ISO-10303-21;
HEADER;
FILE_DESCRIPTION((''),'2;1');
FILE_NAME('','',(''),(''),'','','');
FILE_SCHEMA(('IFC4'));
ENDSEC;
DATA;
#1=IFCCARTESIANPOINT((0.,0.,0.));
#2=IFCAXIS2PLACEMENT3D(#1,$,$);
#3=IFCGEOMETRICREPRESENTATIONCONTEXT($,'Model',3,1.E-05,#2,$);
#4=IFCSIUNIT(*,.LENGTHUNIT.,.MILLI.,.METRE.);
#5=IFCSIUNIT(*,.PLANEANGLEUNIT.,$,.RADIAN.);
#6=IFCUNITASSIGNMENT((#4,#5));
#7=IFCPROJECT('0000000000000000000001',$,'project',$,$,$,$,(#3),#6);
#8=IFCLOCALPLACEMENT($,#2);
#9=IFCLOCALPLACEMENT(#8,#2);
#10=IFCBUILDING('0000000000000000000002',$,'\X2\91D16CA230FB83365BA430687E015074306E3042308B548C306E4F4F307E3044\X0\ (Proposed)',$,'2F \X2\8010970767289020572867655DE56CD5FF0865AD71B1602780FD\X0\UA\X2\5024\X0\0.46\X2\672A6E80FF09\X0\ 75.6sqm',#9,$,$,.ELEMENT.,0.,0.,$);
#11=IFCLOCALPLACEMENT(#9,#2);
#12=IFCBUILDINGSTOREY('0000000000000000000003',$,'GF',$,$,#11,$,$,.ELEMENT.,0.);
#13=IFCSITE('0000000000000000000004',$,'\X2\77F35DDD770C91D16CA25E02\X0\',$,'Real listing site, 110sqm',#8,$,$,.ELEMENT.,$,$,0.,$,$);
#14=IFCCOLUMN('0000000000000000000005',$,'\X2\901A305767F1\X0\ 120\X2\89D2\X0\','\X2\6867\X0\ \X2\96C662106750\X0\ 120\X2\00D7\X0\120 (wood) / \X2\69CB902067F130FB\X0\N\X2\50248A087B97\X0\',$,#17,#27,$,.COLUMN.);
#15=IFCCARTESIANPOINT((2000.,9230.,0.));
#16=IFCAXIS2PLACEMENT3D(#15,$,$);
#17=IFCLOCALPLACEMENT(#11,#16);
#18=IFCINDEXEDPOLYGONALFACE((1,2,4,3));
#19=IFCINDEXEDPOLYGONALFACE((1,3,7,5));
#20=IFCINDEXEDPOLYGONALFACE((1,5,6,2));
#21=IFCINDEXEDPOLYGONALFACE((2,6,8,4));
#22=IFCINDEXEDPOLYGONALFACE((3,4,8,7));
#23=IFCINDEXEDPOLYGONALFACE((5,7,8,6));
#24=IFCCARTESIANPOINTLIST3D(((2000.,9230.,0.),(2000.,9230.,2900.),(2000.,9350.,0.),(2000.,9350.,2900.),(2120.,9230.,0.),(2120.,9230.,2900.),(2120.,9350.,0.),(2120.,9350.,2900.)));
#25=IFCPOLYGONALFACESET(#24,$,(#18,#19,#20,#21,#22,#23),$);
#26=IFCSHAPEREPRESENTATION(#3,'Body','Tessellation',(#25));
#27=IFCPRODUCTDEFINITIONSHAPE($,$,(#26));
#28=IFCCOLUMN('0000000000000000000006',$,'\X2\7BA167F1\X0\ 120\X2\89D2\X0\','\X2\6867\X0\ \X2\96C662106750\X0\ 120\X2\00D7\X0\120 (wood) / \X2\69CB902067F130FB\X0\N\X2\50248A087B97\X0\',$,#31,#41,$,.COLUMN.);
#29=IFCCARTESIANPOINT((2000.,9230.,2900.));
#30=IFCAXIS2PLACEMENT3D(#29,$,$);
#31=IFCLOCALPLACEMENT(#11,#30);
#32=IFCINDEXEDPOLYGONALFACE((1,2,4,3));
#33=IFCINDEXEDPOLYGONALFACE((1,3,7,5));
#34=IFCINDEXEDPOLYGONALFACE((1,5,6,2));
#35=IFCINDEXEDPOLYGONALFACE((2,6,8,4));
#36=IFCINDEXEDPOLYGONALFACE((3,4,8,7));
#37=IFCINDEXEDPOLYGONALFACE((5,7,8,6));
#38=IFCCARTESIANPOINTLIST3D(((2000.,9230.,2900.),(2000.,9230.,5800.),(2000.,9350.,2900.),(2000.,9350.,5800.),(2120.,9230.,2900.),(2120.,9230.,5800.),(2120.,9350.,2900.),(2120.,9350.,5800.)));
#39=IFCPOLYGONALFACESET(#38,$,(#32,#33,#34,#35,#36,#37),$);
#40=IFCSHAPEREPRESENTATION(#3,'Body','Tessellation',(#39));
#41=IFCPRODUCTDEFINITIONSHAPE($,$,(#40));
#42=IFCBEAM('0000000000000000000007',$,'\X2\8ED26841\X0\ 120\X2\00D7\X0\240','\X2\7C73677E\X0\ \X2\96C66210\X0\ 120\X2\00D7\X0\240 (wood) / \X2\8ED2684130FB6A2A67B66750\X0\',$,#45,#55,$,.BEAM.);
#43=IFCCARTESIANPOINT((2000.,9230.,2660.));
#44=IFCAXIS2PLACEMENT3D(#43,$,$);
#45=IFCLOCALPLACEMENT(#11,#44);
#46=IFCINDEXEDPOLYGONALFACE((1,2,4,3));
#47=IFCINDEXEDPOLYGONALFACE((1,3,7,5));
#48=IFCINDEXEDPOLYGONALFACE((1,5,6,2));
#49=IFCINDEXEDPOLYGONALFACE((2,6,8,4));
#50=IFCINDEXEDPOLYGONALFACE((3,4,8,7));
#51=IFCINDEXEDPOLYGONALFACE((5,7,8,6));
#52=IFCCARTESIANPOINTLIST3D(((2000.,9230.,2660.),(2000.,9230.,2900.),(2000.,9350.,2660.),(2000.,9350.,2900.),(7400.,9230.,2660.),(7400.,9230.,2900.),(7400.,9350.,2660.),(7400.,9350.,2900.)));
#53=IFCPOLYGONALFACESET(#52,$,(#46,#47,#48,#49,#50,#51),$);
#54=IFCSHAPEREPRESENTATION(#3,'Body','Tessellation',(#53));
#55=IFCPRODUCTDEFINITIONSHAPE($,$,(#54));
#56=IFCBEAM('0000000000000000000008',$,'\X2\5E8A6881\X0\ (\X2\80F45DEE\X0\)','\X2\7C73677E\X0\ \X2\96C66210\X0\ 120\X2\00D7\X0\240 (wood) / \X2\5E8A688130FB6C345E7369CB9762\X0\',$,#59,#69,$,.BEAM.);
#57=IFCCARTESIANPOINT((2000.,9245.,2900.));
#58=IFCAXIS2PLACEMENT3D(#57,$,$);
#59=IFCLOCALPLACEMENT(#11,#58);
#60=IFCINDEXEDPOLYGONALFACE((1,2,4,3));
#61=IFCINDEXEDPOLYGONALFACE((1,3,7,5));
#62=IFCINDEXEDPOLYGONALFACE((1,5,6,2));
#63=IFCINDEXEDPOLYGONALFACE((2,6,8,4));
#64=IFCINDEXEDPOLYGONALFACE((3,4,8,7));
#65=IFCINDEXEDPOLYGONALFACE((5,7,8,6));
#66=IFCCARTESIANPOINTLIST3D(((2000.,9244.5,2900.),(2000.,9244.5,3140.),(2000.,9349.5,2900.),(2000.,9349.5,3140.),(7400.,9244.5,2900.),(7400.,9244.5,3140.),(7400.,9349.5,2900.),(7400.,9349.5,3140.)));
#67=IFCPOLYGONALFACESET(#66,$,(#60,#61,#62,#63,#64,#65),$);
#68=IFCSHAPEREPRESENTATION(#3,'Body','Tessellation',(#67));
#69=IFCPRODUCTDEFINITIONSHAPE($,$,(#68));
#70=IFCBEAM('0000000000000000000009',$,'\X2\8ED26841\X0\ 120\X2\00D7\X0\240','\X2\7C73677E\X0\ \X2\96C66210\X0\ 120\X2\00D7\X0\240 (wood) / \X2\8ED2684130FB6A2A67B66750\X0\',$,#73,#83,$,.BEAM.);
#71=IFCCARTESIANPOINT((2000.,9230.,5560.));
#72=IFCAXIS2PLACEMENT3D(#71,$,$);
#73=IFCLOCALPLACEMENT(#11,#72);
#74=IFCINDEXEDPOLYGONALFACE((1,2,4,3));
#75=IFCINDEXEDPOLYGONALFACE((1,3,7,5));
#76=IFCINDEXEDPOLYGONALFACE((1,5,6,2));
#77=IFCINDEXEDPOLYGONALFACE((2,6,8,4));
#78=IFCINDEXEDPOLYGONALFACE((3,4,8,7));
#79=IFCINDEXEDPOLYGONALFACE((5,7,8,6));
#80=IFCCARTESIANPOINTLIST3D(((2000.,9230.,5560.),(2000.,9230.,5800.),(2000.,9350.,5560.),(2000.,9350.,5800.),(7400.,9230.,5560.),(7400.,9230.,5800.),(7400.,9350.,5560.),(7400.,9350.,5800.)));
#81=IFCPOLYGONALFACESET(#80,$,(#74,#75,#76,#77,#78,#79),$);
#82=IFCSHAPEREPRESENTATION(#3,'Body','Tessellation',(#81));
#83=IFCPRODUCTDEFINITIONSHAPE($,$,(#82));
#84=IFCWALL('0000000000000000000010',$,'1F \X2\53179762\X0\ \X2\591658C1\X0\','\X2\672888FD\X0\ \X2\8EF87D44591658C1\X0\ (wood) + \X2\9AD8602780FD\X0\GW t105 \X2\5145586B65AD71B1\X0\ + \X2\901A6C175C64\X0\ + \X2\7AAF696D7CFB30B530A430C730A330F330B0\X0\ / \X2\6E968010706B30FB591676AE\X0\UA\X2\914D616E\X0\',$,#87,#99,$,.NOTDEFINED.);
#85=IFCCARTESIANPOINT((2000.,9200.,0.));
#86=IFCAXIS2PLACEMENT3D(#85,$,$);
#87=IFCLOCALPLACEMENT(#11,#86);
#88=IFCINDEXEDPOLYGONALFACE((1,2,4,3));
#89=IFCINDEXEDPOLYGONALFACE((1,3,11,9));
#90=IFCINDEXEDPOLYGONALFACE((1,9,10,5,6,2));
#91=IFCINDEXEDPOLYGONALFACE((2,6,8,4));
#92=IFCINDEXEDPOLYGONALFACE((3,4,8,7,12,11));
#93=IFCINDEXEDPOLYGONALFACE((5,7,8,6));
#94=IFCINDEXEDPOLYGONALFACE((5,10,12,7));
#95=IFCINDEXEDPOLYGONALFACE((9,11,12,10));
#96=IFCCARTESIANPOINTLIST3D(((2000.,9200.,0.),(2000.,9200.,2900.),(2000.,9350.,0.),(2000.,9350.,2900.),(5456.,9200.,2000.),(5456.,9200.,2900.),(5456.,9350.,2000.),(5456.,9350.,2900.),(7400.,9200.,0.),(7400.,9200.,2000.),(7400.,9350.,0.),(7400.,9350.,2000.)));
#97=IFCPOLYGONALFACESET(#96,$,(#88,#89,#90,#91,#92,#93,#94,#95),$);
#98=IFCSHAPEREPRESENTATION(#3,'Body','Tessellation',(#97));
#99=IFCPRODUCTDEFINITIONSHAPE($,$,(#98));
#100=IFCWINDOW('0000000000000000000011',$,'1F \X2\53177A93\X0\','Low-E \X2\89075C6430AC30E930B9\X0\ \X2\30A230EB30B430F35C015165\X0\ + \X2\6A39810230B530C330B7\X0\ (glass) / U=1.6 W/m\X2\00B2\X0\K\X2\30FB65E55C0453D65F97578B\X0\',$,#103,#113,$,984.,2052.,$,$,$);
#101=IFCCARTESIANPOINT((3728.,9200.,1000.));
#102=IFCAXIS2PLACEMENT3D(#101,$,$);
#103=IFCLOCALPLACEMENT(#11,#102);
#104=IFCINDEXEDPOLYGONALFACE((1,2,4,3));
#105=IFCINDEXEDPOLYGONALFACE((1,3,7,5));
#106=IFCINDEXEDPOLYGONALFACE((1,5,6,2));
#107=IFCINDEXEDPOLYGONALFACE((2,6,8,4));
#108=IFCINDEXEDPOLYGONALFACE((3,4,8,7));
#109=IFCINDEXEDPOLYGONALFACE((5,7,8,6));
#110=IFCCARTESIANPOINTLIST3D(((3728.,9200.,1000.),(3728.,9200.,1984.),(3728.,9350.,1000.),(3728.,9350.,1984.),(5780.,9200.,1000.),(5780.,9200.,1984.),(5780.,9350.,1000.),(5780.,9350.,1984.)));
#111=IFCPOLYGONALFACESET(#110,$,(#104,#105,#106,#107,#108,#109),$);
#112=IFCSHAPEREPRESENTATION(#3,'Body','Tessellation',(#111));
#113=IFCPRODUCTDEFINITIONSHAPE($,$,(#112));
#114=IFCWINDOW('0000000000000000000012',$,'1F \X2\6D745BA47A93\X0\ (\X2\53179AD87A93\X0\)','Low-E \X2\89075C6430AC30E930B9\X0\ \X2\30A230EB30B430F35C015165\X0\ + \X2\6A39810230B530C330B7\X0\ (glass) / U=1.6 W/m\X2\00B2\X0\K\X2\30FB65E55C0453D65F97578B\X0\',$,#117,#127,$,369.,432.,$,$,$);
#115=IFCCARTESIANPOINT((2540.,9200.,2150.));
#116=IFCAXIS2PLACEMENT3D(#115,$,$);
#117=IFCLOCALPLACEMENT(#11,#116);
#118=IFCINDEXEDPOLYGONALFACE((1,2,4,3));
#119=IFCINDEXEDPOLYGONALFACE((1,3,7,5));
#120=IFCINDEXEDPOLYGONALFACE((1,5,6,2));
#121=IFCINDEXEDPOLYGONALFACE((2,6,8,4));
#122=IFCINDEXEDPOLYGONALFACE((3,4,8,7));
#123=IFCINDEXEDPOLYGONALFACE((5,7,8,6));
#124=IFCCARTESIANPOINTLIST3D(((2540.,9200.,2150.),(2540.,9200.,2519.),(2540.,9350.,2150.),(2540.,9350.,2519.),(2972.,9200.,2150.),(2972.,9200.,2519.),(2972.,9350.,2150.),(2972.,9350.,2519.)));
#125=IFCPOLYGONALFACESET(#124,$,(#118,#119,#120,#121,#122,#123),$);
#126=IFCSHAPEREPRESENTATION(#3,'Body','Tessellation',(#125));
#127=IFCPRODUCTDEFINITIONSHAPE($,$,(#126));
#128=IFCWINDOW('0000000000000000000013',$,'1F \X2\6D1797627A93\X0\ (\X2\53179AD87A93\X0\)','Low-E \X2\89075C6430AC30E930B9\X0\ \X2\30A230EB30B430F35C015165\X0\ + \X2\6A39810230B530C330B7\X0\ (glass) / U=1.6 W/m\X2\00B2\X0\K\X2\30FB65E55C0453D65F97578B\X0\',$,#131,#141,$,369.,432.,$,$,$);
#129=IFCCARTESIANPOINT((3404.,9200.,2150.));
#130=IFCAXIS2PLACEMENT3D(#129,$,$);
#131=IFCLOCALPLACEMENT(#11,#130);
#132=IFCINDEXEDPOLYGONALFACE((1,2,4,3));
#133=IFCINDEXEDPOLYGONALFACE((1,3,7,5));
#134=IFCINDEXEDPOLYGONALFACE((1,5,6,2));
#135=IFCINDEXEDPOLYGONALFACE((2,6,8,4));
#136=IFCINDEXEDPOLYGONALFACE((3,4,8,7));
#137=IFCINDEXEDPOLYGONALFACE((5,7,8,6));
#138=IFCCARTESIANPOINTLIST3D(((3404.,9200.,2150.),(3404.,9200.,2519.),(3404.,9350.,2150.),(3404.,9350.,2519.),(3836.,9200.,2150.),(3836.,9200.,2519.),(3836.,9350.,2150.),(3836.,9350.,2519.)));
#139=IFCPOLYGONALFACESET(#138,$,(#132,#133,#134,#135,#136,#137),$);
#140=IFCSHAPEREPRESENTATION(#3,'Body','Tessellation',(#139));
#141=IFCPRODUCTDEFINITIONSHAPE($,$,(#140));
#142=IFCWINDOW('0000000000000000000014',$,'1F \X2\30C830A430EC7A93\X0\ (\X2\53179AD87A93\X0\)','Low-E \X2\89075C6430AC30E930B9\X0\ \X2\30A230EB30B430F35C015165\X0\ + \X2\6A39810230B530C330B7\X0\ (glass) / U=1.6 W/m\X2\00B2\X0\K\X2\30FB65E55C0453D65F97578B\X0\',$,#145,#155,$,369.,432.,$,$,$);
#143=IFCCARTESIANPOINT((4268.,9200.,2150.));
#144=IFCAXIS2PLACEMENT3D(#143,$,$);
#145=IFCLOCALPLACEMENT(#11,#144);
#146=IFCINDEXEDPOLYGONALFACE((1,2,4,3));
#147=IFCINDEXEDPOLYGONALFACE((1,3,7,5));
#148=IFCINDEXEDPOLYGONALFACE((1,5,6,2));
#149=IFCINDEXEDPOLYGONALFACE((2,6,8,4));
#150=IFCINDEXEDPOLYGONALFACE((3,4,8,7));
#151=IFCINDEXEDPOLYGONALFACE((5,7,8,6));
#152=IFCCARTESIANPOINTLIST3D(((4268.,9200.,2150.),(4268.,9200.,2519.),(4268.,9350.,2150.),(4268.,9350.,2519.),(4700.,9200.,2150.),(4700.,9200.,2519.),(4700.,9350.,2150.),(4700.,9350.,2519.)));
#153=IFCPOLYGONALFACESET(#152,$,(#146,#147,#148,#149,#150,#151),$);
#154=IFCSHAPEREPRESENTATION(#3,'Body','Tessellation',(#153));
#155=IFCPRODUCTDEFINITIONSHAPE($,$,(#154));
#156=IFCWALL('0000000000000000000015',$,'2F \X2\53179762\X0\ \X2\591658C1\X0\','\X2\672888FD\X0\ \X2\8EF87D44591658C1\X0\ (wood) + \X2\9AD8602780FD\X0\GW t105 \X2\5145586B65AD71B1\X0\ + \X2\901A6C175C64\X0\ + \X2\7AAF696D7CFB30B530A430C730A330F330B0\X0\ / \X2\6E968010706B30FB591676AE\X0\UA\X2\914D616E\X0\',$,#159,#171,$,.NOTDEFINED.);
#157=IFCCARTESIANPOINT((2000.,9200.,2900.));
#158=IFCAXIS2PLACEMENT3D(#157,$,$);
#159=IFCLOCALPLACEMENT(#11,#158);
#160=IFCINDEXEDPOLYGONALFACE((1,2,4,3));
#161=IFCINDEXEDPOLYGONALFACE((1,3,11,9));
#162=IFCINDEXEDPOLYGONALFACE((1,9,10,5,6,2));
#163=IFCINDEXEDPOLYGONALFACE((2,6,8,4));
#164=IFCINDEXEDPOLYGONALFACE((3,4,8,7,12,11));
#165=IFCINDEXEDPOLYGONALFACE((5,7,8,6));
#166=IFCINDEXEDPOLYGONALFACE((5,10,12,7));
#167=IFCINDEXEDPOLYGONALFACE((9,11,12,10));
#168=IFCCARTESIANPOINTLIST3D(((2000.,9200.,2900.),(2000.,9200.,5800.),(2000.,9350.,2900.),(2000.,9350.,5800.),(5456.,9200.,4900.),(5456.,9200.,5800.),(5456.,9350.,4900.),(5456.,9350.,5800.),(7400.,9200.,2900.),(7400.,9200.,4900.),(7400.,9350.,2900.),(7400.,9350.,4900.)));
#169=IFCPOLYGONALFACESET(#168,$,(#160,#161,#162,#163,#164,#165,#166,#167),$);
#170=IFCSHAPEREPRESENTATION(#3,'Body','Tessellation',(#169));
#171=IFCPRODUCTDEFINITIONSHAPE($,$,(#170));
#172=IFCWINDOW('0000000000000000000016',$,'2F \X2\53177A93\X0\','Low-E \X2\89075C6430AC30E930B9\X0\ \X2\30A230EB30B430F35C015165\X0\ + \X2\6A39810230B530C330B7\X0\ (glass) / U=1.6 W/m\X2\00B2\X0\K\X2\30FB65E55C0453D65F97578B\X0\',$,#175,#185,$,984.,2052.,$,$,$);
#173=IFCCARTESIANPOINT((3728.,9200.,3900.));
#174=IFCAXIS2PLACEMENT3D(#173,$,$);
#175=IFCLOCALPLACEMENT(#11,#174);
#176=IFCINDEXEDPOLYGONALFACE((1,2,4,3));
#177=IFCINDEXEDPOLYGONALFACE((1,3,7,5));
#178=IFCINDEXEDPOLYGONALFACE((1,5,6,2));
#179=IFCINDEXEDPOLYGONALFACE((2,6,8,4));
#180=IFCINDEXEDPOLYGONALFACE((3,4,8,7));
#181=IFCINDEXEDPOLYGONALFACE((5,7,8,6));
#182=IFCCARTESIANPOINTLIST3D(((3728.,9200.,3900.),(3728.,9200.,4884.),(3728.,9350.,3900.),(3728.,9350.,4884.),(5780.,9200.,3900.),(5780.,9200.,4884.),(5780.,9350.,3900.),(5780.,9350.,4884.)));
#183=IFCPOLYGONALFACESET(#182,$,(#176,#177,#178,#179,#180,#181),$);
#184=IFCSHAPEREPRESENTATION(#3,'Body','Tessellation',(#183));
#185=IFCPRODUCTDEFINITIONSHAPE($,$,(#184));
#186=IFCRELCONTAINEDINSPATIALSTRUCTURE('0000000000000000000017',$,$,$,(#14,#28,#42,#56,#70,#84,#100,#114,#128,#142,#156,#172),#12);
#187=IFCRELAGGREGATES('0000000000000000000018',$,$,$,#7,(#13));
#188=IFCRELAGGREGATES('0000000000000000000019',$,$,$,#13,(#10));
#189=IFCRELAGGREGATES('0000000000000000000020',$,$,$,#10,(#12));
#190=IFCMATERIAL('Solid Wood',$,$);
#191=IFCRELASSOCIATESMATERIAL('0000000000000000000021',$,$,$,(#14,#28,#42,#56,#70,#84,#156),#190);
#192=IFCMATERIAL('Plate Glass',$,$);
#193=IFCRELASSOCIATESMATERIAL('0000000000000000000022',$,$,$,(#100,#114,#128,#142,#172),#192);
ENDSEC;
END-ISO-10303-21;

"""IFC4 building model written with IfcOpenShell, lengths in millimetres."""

from ifc_helpers import new_model, si_unit, frame, frame_2d, origin, place, context, project, spatial, rectangle, extrude, material, element, fill, save


model = new_model("IFC4")

# Units and contexts
model_context = context("Model", 3, precision=1e-05, world=origin())
ifc_project = project(units=[si_unit("LENGTHUNIT", "METRE", prefix="MILLI"), si_unit("PLANEANGLEUNIT", "RADIAN")], contexts=[model_context])

# Site, building, storey
site_placement = place(None, origin())
site = spatial("IfcSite", under=ifc_project, at=site_placement, Name="石川県金沢市", ObjectType="Real listing site, 110sqm", CompositionType="ELEMENT", RefElevation=0.0)
building_placement = place(site_placement, origin())
building = spatial("IfcBuilding", under=site, at=building_placement, Name="金沢・茶室と縁側のある和の住まい (Proposed)", ObjectType="2F 耐震木造在来工法（断熱性能UA値0.46未満） 75.6sqm", CompositionType="ELEMENT", ElevationOfRefHeight=0.0, ElevationOfTerrain=0.0)
storey_placement = place(building_placement, origin())
storey = spatial("IfcBuildingStorey", under=building, at=storey_placement, Name="GF", CompositionType="ELEMENT", Elevation=0.0)

# Columns
ifc_material_1 = material(Name="Solid Wood")
column_1_placement = place(storey_placement, frame((2000.0, 9230.0, 0.0)))
element("IfcColumn", 1, at=column_1_placement, inside=storey, material=ifc_material_1, Name="通し柱 120角", Description="桧 集成材 120×120 (wood) / 構造柱・N値計算", PredefinedType="COLUMN", context=model_context, shape_type="SweptSolid", body=[
    extrude(rectangle(XDim=120.0, YDim=120.0, at=frame_2d((60.0, 60.0))), frame((2000.0, 9230.0, 0.0)), (0.0, 0.0, 1.0), 2900.0),
])
column_2_placement = place(storey_placement, frame((2000.0, 9230.0, 2900.0)))
element("IfcColumn", 2, at=column_2_placement, inside=storey, material=ifc_material_1, Name="管柱 120角", Description="桧 集成材 120×120 (wood) / 構造柱・N値計算", PredefinedType="COLUMN", context=model_context, shape_type="SweptSolid", body=[
    extrude(rectangle(XDim=120.0, YDim=120.0, at=frame_2d((60.0, 60.0))), frame((2000.0, 9230.0, 2900.0)), (0.0, 0.0, 1.0), 2900.0),
])

# Beams
beam_1_placement = place(storey_placement, frame((2000.0, 9230.0, 2660.0)))
element("IfcBeam", 3, at=beam_1_placement, inside=storey, material=ifc_material_1, Name="軒桁 120×240", Description="米松 集成 120×240 (wood) / 軒桁・横架材", PredefinedType="BEAM", context=model_context, shape_type="SweptSolid", body=[
    extrude(rectangle(XDim=5400.0, YDim=120.0, at=frame_2d((2700.0, 60.0))), frame((2000.0, 9230.0, 2660.0)), (0.0, 0.0, 1.0), 240.0),
])
beam_2_placement = place(storey_placement, frame((2000.0, 9245.0, 2900.0)))
element("IfcBeam", 4, at=beam_2_placement, inside=storey, material=ifc_material_1, Name="床梁 (胴差)", Description="米松 集成 120×240 (wood) / 床梁・水平構面", PredefinedType="BEAM", context=model_context, shape_type="SweptSolid", body=[
    extrude(rectangle(XDim=5400.0, YDim=105.0, at=frame_2d((2700.0, 52.0))), frame((2000.0, 9245.0, 2900.0)), (0.0, 0.0, 1.0), 240.0),
])
beam_3_placement = place(storey_placement, frame((2000.0, 9230.0, 5560.0)))
element("IfcBeam", 5, at=beam_3_placement, inside=storey, material=ifc_material_1, Name="軒桁 120×240", Description="米松 集成 120×240 (wood) / 軒桁・横架材", PredefinedType="BEAM", context=model_context, shape_type="SweptSolid", body=[
    extrude(rectangle(XDim=5400.0, YDim=120.0, at=frame_2d((2700.0, 60.0))), frame((2000.0, 9230.0, 5560.0)), (0.0, 0.0, 1.0), 240.0),
])

# Wall, openings, windows
wall_1_placement = place(storey_placement, frame((2000.0, 9200.0, 0.0)))
wall_1 = element("IfcWall", 6, at=wall_1_placement, inside=storey, material=ifc_material_1, Name="1F 北面 外壁", Description="木製 軸組外壁 (wood) + 高性能GW t105 充填断熱 + 通気層 + 窯業系サイディング / 準耐火・外皮UA配慮", PredefinedType="NOTDEFINED", context=model_context, shape_type="SweptSolid", body=[
    extrude(rectangle(XDim=5400.0, YDim=150.0, at=frame_2d((2700.0, 75.0))), frame((2000.0, 9200.0, 0.0)), (0.0, 0.0, 1.0), 2900.0),
])
opening_1_placement = place(storey_placement, frame((3728.0, 9200.0, 1000.0)))
opening_1 = element("IfcOpeningElement", 7, at=opening_1_placement, cuts=wall_1, PredefinedType="NOTDEFINED", context=model_context, shape_type="SweptSolid", body=[
    extrude(rectangle(XDim=2052.0, YDim=150.0, at=frame_2d((1026.0, 75.0))), frame((3728.0, 9200.0, 1000.0)), (0.0, 0.0, 1.0), 984.0),
])
opening_2_placement = place(storey_placement, frame((2540.0, 9200.0, 2150.0)))
opening_2 = element("IfcOpeningElement", 8, at=opening_2_placement, cuts=wall_1, PredefinedType="NOTDEFINED", context=model_context, shape_type="SweptSolid", body=[
    extrude(rectangle(XDim=432.0, YDim=150.0, at=frame_2d((216.0, 75.0))), frame((2540.0, 9200.0, 2150.0)), (0.0, 0.0, 1.0), 369.0),
])
opening_3_placement = place(storey_placement, frame((3404.0, 9200.0, 2150.0)))
opening_3 = element("IfcOpeningElement", 9, at=opening_3_placement, cuts=wall_1, PredefinedType="NOTDEFINED", context=model_context, shape_type="SweptSolid", body=[
    extrude(rectangle(XDim=432.0, YDim=150.0, at=frame_2d((216.0, 75.0))), frame((3404.0, 9200.0, 2150.0)), (0.0, 0.0, 1.0), 369.0),
])
opening_4_placement = place(storey_placement, frame((4268.0, 9200.0, 2150.0)))
opening_4 = element("IfcOpeningElement", 10, at=opening_4_placement, cuts=wall_1, PredefinedType="NOTDEFINED", context=model_context, shape_type="SweptSolid", body=[
    extrude(rectangle(XDim=432.0, YDim=150.0, at=frame_2d((216.0, 75.0))), frame((4268.0, 9200.0, 2150.0)), (0.0, 0.0, 1.0), 369.0),
])
ifc_material_2 = material(Name="Plate Glass")
window_1_placement = place(storey_placement, frame((3728.0, 9200.0, 1000.0)))
window_1 = element("IfcWindow", 11, at=window_1_placement, inside=storey, material=ifc_material_2, Name="1F 北窓", Description="Low-E 複層ガラス アルゴン封入 + 樹脂サッシ (glass) / U=1.6 W/m²K・日射取得型", OverallHeight=984.0, OverallWidth=2052.0, context=model_context, shape_type="SweptSolid", body=[
    extrude(rectangle(XDim=2052.0, YDim=150.0, at=frame_2d((1026.0, 75.0))), frame((3728.0, 9200.0, 1000.0)), (0.0, 0.0, 1.0), 984.0),
])
fill(opening_1, window_1)
window_2_placement = place(storey_placement, frame((2540.0, 9200.0, 2150.0)))
window_2 = element("IfcWindow", 12, at=window_2_placement, inside=storey, material=ifc_material_2, Name="1F 浴室窓 (北高窓)", Description="Low-E 複層ガラス アルゴン封入 + 樹脂サッシ (glass) / U=1.6 W/m²K・日射取得型", OverallHeight=369.0, OverallWidth=432.0, context=model_context, shape_type="SweptSolid", body=[
    extrude(rectangle(XDim=432.0, YDim=150.0, at=frame_2d((216.0, 75.0))), frame((2540.0, 9200.0, 2150.0)), (0.0, 0.0, 1.0), 369.0),
])
fill(opening_2, window_2)
window_3_placement = place(storey_placement, frame((3404.0, 9200.0, 2150.0)))
window_3 = element("IfcWindow", 13, at=window_3_placement, inside=storey, material=ifc_material_2, Name="1F 洗面窓 (北高窓)", Description="Low-E 複層ガラス アルゴン封入 + 樹脂サッシ (glass) / U=1.6 W/m²K・日射取得型", OverallHeight=369.0, OverallWidth=432.0, context=model_context, shape_type="SweptSolid", body=[
    extrude(rectangle(XDim=432.0, YDim=150.0, at=frame_2d((216.0, 75.0))), frame((3404.0, 9200.0, 2150.0)), (0.0, 0.0, 1.0), 369.0),
])
fill(opening_3, window_3)
window_4_placement = place(storey_placement, frame((4268.0, 9200.0, 2150.0)))
window_4 = element("IfcWindow", 14, at=window_4_placement, inside=storey, material=ifc_material_2, Name="1F トイレ窓 (北高窓)", Description="Low-E 複層ガラス アルゴン封入 + 樹脂サッシ (glass) / U=1.6 W/m²K・日射取得型", OverallHeight=369.0, OverallWidth=432.0, context=model_context, shape_type="SweptSolid", body=[
    extrude(rectangle(XDim=432.0, YDim=150.0, at=frame_2d((216.0, 75.0))), frame((4268.0, 9200.0, 2150.0)), (0.0, 0.0, 1.0), 369.0),
])
fill(opening_4, window_4)

# Wall, opening, window
wall_2_placement = place(storey_placement, frame((2000.0, 9200.0, 2900.0)))
wall_2 = element("IfcWall", 15, at=wall_2_placement, inside=storey, material=ifc_material_1, Name="2F 北面 外壁", Description="木製 軸組外壁 (wood) + 高性能GW t105 充填断熱 + 通気層 + 窯業系サイディング / 準耐火・外皮UA配慮", PredefinedType="NOTDEFINED", context=model_context, shape_type="SweptSolid", body=[
    extrude(rectangle(XDim=5400.0, YDim=150.0, at=frame_2d((2700.0, 75.0))), frame((2000.0, 9200.0, 2900.0)), (0.0, 0.0, 1.0), 2900.0),
])
opening_5_placement = place(storey_placement, frame((3728.0, 9200.0, 3900.0)))
opening_5 = element("IfcOpeningElement", 16, at=opening_5_placement, cuts=wall_2, PredefinedType="NOTDEFINED", context=model_context, shape_type="SweptSolid", body=[
    extrude(rectangle(XDim=2052.0, YDim=150.0, at=frame_2d((1026.0, 75.0))), frame((3728.0, 9200.0, 3900.0)), (0.0, 0.0, 1.0), 984.0),
])
window_5_placement = place(storey_placement, frame((3728.0, 9200.0, 3900.0)))
window_5 = element("IfcWindow", 17, at=window_5_placement, inside=storey, material=ifc_material_2, Name="2F 北窓", Description="Low-E 複層ガラス アルゴン封入 + 樹脂サッシ (glass) / U=1.6 W/m²K・日射取得型", OverallHeight=984.0, OverallWidth=2052.0, context=model_context, shape_type="SweptSolid", body=[
    extrude(rectangle(XDim=2052.0, YDim=150.0, at=frame_2d((1026.0, 75.0))), frame((3728.0, 9200.0, 3900.0)), (0.0, 0.0, 1.0), 984.0),
])
fill(opening_5, window_5)

save(model, "model.ifc")
